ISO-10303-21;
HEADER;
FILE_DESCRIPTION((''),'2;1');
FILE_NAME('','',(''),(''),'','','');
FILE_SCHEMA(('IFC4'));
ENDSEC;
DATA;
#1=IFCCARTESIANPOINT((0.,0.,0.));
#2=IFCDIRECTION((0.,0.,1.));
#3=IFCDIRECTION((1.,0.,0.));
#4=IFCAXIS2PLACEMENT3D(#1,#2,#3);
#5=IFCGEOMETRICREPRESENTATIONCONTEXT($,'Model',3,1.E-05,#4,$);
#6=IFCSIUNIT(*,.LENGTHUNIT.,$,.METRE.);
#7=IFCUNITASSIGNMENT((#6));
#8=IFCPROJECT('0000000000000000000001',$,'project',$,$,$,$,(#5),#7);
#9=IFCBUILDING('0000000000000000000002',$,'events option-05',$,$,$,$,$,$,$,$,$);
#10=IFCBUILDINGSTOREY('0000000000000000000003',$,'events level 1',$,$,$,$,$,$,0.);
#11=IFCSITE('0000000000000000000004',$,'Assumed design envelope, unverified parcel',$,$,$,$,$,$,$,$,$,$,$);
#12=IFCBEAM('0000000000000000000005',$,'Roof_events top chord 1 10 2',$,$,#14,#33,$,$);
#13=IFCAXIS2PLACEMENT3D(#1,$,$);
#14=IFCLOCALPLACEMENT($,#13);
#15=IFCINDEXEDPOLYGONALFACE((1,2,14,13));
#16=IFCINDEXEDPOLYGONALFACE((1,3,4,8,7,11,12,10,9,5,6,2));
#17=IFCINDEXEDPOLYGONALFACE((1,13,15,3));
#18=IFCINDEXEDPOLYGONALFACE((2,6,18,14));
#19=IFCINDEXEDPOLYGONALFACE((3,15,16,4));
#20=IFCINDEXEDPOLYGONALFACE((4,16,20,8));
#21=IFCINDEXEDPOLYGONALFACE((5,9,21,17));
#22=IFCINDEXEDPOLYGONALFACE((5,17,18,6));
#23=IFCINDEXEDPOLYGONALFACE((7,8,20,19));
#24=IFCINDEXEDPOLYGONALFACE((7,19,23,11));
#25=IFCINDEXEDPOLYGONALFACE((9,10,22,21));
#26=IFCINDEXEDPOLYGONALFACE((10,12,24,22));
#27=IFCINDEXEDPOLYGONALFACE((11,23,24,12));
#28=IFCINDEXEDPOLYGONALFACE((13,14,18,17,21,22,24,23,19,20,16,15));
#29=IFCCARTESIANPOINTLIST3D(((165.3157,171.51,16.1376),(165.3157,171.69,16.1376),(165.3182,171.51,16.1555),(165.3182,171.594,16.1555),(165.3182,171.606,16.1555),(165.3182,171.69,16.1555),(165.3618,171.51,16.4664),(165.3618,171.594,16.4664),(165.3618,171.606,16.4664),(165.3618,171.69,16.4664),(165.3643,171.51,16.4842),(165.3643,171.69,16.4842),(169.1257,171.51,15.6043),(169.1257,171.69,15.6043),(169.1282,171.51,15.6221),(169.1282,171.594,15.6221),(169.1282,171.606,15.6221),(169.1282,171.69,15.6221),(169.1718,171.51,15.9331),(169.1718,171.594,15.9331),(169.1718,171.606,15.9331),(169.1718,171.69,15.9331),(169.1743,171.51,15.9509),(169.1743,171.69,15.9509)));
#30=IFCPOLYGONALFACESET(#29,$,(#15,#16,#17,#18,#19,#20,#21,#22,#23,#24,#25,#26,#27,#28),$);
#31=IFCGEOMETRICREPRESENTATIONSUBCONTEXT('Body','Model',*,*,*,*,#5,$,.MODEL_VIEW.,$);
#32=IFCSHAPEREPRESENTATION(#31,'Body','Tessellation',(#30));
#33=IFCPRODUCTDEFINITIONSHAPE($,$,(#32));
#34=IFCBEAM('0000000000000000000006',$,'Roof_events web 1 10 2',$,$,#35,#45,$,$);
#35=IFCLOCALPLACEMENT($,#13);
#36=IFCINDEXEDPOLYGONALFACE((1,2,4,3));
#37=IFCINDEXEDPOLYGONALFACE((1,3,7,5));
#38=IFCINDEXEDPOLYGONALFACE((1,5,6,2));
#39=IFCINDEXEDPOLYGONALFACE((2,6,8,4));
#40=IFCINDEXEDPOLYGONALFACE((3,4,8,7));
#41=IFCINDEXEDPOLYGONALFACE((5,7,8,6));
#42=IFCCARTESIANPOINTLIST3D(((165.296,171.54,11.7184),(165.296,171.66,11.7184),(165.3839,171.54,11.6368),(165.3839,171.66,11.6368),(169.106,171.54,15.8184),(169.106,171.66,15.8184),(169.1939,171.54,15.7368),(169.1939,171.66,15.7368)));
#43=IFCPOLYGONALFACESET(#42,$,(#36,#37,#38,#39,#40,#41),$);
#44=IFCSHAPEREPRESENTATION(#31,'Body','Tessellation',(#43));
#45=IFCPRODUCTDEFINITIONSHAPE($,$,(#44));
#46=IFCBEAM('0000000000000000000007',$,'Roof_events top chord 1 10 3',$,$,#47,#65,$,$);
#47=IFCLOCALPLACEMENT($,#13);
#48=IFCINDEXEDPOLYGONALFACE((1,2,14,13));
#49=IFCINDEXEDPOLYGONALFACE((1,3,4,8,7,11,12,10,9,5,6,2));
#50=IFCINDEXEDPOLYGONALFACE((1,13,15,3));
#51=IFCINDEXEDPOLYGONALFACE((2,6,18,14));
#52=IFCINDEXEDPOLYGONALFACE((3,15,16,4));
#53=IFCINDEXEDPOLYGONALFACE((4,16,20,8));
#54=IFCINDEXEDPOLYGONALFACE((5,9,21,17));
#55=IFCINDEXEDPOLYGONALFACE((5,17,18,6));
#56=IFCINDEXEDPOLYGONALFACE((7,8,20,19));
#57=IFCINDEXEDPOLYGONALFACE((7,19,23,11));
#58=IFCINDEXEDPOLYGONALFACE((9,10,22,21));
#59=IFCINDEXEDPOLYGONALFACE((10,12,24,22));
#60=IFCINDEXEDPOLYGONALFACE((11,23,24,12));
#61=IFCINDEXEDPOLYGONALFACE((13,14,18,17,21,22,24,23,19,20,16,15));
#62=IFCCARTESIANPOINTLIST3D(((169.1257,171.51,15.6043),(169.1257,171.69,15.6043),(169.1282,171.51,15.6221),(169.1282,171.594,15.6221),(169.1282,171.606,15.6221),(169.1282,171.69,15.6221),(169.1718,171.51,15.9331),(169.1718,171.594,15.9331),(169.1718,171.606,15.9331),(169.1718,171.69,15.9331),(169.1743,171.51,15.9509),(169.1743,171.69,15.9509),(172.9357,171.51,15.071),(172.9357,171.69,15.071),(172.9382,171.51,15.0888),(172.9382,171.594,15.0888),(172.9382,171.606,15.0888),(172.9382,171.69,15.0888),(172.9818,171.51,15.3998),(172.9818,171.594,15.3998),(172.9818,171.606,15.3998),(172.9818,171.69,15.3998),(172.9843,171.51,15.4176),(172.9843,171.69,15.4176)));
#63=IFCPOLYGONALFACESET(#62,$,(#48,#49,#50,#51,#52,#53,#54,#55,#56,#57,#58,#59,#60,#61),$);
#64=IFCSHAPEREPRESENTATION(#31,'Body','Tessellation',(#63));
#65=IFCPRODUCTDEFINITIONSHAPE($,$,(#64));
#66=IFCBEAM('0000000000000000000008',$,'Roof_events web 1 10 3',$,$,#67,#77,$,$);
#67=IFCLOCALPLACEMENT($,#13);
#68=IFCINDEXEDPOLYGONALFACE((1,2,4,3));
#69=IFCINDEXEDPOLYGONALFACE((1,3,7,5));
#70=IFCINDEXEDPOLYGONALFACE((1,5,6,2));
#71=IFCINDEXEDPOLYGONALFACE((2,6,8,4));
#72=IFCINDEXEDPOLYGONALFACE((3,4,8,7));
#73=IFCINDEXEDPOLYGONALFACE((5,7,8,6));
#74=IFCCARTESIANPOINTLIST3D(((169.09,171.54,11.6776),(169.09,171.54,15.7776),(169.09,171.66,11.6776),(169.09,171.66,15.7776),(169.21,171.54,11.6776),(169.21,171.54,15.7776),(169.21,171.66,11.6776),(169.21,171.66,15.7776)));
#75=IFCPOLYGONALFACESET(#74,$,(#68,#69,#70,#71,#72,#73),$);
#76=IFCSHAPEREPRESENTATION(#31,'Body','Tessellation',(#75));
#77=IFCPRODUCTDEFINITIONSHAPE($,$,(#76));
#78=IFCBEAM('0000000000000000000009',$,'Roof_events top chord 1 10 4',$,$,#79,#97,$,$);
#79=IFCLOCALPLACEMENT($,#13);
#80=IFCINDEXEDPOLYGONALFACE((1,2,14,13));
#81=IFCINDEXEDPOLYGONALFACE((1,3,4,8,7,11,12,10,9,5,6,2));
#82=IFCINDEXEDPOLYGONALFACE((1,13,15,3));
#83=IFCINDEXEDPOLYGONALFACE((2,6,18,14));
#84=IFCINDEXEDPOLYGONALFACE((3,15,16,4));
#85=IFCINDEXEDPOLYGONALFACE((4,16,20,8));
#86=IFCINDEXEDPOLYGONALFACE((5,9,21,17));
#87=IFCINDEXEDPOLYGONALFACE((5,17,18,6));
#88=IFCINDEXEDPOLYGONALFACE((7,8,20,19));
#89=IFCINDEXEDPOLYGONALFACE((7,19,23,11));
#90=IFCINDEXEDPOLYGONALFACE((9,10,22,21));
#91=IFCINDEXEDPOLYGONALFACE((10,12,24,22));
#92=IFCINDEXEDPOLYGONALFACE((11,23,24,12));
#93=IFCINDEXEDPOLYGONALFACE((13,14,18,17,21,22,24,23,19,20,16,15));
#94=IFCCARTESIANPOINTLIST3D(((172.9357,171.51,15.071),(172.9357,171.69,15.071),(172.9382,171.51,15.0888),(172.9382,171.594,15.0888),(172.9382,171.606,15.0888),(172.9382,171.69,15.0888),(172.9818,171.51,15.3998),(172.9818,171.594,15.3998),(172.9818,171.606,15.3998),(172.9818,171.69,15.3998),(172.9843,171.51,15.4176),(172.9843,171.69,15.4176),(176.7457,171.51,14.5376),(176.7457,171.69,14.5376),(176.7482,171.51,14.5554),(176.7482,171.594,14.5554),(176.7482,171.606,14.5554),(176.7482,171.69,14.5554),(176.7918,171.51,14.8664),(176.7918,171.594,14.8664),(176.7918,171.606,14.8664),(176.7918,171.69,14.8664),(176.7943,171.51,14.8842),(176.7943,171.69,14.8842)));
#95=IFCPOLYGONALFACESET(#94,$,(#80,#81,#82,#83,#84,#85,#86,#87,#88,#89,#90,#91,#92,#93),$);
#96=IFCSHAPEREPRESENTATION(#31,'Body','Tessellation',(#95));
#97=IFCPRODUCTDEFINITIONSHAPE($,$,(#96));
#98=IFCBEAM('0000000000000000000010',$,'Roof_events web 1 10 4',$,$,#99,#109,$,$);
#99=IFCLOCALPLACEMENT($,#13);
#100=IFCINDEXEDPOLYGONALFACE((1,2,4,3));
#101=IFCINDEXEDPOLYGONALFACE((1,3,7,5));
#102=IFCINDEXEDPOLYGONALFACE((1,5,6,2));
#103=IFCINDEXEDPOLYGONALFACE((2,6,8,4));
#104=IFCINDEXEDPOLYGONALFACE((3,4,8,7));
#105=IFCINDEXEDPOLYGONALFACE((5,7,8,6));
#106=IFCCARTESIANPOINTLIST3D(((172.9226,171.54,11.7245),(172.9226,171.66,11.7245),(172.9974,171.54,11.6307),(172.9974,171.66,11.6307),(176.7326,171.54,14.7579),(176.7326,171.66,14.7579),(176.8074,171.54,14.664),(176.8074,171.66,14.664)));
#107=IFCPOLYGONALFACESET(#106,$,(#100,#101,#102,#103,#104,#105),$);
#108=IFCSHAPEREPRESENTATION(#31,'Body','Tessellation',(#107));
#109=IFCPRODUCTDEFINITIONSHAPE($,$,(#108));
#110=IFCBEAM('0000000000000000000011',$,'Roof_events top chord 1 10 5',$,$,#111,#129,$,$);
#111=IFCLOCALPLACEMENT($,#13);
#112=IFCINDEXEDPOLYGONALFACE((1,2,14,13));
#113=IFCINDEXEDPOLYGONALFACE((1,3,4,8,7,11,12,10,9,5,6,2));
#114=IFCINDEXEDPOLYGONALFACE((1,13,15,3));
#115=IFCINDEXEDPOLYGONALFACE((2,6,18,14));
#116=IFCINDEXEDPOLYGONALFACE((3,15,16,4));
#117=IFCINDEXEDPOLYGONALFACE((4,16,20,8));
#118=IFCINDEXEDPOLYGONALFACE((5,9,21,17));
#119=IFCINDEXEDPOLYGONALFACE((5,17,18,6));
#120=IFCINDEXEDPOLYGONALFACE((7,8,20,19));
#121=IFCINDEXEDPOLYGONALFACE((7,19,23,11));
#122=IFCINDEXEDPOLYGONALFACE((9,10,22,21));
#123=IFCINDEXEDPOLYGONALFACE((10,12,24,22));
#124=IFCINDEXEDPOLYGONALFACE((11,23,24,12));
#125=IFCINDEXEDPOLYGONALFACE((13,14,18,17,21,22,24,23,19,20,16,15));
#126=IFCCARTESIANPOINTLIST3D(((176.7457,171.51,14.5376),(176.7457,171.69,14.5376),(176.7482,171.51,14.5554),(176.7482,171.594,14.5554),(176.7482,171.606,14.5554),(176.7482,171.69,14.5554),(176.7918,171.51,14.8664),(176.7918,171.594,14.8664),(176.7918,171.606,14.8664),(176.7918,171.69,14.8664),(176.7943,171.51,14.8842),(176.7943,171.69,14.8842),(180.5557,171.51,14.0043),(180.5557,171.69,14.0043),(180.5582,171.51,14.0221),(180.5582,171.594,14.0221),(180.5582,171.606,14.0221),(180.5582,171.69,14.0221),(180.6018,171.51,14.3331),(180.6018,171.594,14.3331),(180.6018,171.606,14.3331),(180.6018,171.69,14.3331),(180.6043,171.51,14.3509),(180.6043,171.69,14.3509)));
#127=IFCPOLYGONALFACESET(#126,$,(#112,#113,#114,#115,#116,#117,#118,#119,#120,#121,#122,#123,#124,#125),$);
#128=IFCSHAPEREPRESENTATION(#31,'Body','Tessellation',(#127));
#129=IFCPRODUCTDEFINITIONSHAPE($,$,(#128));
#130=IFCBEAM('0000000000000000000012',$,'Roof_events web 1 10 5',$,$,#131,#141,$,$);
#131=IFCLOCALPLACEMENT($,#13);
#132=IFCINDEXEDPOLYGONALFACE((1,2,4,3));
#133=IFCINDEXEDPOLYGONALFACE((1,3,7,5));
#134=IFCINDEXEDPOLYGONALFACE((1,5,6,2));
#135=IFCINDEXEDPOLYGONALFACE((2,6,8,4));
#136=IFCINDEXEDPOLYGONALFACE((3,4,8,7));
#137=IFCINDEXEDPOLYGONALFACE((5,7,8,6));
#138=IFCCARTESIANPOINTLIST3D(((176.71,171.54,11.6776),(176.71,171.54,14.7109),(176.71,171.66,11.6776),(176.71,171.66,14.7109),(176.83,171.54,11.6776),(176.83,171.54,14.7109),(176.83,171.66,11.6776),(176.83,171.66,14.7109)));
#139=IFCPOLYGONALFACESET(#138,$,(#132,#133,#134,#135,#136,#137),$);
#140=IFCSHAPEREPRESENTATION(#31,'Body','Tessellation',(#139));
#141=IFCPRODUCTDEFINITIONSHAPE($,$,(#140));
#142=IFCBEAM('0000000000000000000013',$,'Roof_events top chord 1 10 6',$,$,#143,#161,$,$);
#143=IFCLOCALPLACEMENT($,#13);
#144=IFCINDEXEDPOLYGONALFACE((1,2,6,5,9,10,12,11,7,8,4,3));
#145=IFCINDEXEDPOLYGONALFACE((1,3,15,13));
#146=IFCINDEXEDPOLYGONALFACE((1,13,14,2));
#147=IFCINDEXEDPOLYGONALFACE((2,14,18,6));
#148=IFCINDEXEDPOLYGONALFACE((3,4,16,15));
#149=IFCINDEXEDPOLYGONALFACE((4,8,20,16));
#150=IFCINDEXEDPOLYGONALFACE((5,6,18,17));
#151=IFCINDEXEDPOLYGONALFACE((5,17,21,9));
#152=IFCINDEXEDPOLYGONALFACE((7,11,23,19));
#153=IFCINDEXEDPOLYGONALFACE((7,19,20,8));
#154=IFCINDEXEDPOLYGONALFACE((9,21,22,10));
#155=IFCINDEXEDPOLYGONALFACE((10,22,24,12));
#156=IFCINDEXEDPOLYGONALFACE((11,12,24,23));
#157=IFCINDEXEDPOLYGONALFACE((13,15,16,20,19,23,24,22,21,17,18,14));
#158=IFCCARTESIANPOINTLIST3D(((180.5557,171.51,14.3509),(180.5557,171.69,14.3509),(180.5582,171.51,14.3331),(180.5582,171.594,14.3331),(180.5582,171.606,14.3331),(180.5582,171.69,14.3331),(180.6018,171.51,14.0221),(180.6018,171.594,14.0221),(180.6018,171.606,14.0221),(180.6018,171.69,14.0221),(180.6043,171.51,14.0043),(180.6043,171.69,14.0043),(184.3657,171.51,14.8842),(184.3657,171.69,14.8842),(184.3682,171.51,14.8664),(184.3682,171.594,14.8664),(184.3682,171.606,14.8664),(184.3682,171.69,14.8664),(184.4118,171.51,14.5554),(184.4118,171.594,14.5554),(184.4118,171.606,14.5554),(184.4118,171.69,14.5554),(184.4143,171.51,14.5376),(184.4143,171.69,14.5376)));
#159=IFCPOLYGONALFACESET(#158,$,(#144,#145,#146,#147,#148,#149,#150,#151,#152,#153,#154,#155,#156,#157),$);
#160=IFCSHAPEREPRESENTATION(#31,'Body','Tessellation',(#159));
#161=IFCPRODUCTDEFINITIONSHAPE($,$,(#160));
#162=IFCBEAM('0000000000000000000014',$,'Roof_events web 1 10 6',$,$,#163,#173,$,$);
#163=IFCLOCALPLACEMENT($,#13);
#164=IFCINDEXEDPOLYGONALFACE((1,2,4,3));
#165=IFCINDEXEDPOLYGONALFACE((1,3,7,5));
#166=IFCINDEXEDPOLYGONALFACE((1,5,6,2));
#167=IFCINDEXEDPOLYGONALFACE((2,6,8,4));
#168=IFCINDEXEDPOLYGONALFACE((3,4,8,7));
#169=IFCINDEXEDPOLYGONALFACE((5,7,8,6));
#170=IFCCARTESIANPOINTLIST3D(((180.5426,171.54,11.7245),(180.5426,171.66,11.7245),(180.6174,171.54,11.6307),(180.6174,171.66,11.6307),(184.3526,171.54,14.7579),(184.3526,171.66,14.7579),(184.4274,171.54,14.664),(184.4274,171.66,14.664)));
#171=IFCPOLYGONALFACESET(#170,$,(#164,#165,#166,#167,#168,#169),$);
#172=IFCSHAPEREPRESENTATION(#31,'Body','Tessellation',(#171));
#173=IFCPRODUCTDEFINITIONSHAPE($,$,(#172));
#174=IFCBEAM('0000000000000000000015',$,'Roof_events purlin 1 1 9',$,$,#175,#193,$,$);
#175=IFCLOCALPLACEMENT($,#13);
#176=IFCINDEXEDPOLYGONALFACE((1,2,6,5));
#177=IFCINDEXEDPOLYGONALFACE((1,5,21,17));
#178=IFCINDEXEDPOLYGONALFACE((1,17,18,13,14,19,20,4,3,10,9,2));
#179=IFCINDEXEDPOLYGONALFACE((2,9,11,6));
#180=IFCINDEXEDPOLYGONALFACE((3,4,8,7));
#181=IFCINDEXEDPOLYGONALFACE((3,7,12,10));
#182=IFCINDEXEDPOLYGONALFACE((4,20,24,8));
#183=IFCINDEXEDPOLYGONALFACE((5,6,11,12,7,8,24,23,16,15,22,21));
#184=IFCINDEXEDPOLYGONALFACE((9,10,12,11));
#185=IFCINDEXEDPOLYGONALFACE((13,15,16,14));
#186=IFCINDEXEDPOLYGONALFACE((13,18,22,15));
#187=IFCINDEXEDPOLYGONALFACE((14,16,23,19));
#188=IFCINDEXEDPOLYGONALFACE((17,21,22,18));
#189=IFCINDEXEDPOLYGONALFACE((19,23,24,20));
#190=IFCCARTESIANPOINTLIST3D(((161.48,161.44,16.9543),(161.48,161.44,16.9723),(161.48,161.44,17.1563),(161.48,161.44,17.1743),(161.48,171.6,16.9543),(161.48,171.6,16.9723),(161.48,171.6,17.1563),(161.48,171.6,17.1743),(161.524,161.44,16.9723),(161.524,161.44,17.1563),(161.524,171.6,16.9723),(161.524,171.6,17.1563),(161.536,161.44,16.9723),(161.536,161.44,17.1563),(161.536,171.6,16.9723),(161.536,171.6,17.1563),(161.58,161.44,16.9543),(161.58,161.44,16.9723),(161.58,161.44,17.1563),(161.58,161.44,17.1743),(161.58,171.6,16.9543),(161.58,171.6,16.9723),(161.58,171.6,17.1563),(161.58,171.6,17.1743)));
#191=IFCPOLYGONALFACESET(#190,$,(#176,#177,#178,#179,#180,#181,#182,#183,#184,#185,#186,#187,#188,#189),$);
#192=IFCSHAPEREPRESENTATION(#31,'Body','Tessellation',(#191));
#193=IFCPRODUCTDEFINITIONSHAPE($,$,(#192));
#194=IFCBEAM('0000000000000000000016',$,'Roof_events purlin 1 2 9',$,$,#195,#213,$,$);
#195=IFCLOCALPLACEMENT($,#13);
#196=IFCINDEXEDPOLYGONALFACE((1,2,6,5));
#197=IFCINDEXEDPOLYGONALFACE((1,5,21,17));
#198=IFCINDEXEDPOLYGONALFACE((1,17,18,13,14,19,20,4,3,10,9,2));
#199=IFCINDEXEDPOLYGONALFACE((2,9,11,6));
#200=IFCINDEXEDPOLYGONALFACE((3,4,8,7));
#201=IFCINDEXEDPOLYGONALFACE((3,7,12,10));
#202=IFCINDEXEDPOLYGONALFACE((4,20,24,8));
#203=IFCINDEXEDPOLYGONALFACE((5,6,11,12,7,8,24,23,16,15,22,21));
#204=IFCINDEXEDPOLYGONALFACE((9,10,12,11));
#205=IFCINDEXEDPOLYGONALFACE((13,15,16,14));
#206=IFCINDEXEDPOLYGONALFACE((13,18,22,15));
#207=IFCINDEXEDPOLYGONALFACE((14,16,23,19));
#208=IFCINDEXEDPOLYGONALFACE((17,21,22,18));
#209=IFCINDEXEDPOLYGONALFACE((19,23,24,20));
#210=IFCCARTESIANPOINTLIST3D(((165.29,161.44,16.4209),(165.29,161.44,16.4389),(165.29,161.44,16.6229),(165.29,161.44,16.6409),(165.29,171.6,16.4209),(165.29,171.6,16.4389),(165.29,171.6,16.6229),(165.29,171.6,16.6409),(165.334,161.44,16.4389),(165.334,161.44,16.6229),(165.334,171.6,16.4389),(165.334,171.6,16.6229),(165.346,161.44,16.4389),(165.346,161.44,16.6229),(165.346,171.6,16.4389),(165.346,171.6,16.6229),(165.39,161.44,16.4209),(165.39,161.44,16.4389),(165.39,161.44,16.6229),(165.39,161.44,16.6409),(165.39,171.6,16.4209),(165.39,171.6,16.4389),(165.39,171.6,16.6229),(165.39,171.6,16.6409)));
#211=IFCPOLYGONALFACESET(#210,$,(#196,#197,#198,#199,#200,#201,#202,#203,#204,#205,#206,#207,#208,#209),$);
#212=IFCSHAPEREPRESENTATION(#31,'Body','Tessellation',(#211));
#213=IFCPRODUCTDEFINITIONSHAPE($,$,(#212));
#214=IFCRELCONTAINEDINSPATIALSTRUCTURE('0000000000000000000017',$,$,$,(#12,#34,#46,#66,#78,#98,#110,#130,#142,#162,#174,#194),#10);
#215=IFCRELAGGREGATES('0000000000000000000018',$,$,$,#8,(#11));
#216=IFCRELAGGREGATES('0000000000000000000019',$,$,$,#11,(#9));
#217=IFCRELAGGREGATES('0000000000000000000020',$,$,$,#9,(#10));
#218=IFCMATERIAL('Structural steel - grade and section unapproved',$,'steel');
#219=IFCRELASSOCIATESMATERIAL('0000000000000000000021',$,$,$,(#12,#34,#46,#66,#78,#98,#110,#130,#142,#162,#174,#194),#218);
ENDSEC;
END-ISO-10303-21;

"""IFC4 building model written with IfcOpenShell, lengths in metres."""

from ifc_helpers import new_model, si_unit, frame, origin_with_axes, place, context, subcontext, project, spatial, rectangle, i_section, extrude, material, element, save


model = new_model("IFC4")

# Units and contexts
model_context = context("Model", 3, precision=1e-05, world=origin_with_axes())
body_context = subcontext(model_context, "Body", "Model", "MODEL_VIEW")
ifc_project = project(units=[si_unit("LENGTHUNIT", "METRE")], contexts=[model_context])

# Site, building, storey
site = spatial("IfcSite", under=ifc_project, Name="Assumed design envelope, unverified parcel")
building = spatial("IfcBuilding", under=site, Name="events option-05")
storey = spatial("IfcBuildingStorey", under=building, Name="events level 1", Elevation=0.0)

# Beams
ifc_material_1 = material(Name="Structural steel - grade and section unapproved", Category="steel")
beam_1_placement = place(None, frame((165.34, 171.6, 16.3109), z_axis=(0.990344, 0.0, -0.138631), x_axis=(0.0, 1.0, 0.0)))
element("IfcBeam", 1, at=beam_1_placement, inside=storey, material=ifc_material_1, Name="Roof_events top chord 1 10 2", context=body_context, shape_type="SweptSolid", body=[
    extrude(i_section(OverallWidth=0.18, OverallDepth=0.35, WebThickness=0.012, FlangeThickness=0.018, FilletRadius=0.0), origin_with_axes(), (0.0, 0.0, 1.0), 3.8471),
])
beam_2_placement = place(None, frame((165.34, 171.6, 11.6776), z_axis=(0.680725, 0.0, 0.732539), x_axis=(0.0, 1.0, 0.0)))
element("IfcBeam", 2, at=beam_2_placement, inside=storey, material=ifc_material_1, Name="Roof_events web 1 10 2", context=body_context, shape_type="SweptSolid", body=[
    extrude(rectangle(XDim=0.12, YDim=0.12), origin_with_axes(), (0.0, 0.0, 1.0), 5.597),
])
beam_3_placement = place(None, frame((169.15, 171.6, 15.7776), z_axis=(0.990344, 0.0, -0.138631), x_axis=(0.0, 1.0, 0.0)))
element("IfcBeam", 3, at=beam_3_placement, inside=storey, material=ifc_material_1, Name="Roof_events top chord 1 10 3", context=body_context, shape_type="SweptSolid", body=[
    extrude(i_section(OverallWidth=0.18, OverallDepth=0.35, WebThickness=0.012, FlangeThickness=0.018, FilletRadius=0.0), origin_with_axes(), (0.0, 0.0, 1.0), 3.8472),
])
beam_4_placement = place(None, frame((169.15, 171.6, 11.6776), z_axis=(0.0, 0.0, 1.0), x_axis=(-1.0, 0.0, 0.0)))
element("IfcBeam", 4, at=beam_4_placement, inside=storey, material=ifc_material_1, Name="Roof_events web 1 10 3", context=body_context, shape_type="SweptSolid", body=[
    extrude(rectangle(XDim=0.12, YDim=0.12), origin_with_axes(), (0.0, 0.0, 1.0), 4.1),
])
beam_5_placement = place(None, frame((172.96, 171.6, 15.2443), z_axis=(0.990344, 0.0, -0.138631), x_axis=(0.0, 1.0, 0.0)))
element("IfcBeam", 5, at=beam_5_placement, inside=storey, material=ifc_material_1, Name="Roof_events top chord 1 10 4", context=body_context, shape_type="SweptSolid", body=[
    extrude(i_section(OverallWidth=0.18, OverallDepth=0.35, WebThickness=0.012, FlangeThickness=0.018, FilletRadius=0.0), origin_with_axes(), (0.0, 0.0, 1.0), 3.8471),
])
beam_6_placement = place(None, frame((172.96, 171.6, 11.6776), z_axis=(0.782336, 0.0, 0.622857), x_axis=(0.0, 1.0, 0.0)))
element("IfcBeam", 6, at=beam_6_placement, inside=storey, material=ifc_material_1, Name="Roof_events web 1 10 4", context=body_context, shape_type="SweptSolid", body=[
    extrude(rectangle(XDim=0.12, YDim=0.12), origin_with_axes(), (0.0, 0.0, 1.0), 4.87),
])
beam_7_placement = place(None, frame((176.77, 171.6, 14.7109), z_axis=(0.990344, 0.0, -0.138631), x_axis=(0.0, 1.0, 0.0)))
element("IfcBeam", 7, at=beam_7_placement, inside=storey, material=ifc_material_1, Name="Roof_events top chord 1 10 5", context=body_context, shape_type="SweptSolid", body=[
    extrude(i_section(OverallWidth=0.18, OverallDepth=0.35, WebThickness=0.012, FlangeThickness=0.018, FilletRadius=0.0), origin_with_axes(), (0.0, 0.0, 1.0), 3.8471),
])
beam_8_placement = place(None, frame((176.77, 171.6, 11.6776), z_axis=(0.0, 0.0, 1.0), x_axis=(-1.0, 0.0, 0.0)))
element("IfcBeam", 8, at=beam_8_placement, inside=storey, material=ifc_material_1, Name="Roof_events web 1 10 5", context=body_context, shape_type="SweptSolid", body=[
    extrude(rectangle(XDim=0.12, YDim=0.12), origin_with_axes(), (0.0, 0.0, 1.0), 3.0333),
])
beam_9_placement = place(None, frame((180.58, 171.6, 14.1776), z_axis=(0.990344, 0.0, 0.138631), x_axis=(0.0, 1.0, 0.0)))
element("IfcBeam", 9, at=beam_9_placement, inside=storey, material=ifc_material_1, Name="Roof_events top chord 1 10 6", context=body_context, shape_type="SweptSolid", body=[
    extrude(i_section(OverallWidth=0.18, OverallDepth=0.35, WebThickness=0.012, FlangeThickness=0.018, FilletRadius=0.0), origin_with_axes(), (0.0, 0.0, 1.0), 3.8471),
])
beam_10_placement = place(None, frame((180.58, 171.6, 11.6776), z_axis=(0.782336, 0.0, 0.622857), x_axis=(0.0, 1.0, 0.0)))
element("IfcBeam", 10, at=beam_10_placement, inside=storey, material=ifc_material_1, Name="Roof_events web 1 10 6", context=body_context, shape_type="SweptSolid", body=[
    extrude(rectangle(XDim=0.12, YDim=0.12), origin_with_axes(), (0.0, 0.0, 1.0), 4.87),
])
for number, where, z_axis, x_axis, name in (
    (11, (161.53, 161.44, 17.0643), (0.0, 1.0, 0.0), (-1.0, 0.0, 0.0), "Roof_events purlin 1 1 9"),
    (12, (165.34, 161.44, 16.5309), (0.0, 1.0, 0.0), (-1.0, 0.0, 0.0), "Roof_events purlin 1 2 9"),
):
    element("IfcBeam", number, at=place(None, frame(where, z_axis=z_axis, x_axis=x_axis)), inside=storey, material=ifc_material_1, Name=name, context=body_context, shape_type="SweptSolid", body=[
        extrude(i_section(OverallWidth=0.1, OverallDepth=0.22, WebThickness=0.012, FlangeThickness=0.018, FilletRadius=0.0), origin_with_axes(), (0.0, 0.0, 1.0), 10.16),
    ])

save(model, "model.ifc")
